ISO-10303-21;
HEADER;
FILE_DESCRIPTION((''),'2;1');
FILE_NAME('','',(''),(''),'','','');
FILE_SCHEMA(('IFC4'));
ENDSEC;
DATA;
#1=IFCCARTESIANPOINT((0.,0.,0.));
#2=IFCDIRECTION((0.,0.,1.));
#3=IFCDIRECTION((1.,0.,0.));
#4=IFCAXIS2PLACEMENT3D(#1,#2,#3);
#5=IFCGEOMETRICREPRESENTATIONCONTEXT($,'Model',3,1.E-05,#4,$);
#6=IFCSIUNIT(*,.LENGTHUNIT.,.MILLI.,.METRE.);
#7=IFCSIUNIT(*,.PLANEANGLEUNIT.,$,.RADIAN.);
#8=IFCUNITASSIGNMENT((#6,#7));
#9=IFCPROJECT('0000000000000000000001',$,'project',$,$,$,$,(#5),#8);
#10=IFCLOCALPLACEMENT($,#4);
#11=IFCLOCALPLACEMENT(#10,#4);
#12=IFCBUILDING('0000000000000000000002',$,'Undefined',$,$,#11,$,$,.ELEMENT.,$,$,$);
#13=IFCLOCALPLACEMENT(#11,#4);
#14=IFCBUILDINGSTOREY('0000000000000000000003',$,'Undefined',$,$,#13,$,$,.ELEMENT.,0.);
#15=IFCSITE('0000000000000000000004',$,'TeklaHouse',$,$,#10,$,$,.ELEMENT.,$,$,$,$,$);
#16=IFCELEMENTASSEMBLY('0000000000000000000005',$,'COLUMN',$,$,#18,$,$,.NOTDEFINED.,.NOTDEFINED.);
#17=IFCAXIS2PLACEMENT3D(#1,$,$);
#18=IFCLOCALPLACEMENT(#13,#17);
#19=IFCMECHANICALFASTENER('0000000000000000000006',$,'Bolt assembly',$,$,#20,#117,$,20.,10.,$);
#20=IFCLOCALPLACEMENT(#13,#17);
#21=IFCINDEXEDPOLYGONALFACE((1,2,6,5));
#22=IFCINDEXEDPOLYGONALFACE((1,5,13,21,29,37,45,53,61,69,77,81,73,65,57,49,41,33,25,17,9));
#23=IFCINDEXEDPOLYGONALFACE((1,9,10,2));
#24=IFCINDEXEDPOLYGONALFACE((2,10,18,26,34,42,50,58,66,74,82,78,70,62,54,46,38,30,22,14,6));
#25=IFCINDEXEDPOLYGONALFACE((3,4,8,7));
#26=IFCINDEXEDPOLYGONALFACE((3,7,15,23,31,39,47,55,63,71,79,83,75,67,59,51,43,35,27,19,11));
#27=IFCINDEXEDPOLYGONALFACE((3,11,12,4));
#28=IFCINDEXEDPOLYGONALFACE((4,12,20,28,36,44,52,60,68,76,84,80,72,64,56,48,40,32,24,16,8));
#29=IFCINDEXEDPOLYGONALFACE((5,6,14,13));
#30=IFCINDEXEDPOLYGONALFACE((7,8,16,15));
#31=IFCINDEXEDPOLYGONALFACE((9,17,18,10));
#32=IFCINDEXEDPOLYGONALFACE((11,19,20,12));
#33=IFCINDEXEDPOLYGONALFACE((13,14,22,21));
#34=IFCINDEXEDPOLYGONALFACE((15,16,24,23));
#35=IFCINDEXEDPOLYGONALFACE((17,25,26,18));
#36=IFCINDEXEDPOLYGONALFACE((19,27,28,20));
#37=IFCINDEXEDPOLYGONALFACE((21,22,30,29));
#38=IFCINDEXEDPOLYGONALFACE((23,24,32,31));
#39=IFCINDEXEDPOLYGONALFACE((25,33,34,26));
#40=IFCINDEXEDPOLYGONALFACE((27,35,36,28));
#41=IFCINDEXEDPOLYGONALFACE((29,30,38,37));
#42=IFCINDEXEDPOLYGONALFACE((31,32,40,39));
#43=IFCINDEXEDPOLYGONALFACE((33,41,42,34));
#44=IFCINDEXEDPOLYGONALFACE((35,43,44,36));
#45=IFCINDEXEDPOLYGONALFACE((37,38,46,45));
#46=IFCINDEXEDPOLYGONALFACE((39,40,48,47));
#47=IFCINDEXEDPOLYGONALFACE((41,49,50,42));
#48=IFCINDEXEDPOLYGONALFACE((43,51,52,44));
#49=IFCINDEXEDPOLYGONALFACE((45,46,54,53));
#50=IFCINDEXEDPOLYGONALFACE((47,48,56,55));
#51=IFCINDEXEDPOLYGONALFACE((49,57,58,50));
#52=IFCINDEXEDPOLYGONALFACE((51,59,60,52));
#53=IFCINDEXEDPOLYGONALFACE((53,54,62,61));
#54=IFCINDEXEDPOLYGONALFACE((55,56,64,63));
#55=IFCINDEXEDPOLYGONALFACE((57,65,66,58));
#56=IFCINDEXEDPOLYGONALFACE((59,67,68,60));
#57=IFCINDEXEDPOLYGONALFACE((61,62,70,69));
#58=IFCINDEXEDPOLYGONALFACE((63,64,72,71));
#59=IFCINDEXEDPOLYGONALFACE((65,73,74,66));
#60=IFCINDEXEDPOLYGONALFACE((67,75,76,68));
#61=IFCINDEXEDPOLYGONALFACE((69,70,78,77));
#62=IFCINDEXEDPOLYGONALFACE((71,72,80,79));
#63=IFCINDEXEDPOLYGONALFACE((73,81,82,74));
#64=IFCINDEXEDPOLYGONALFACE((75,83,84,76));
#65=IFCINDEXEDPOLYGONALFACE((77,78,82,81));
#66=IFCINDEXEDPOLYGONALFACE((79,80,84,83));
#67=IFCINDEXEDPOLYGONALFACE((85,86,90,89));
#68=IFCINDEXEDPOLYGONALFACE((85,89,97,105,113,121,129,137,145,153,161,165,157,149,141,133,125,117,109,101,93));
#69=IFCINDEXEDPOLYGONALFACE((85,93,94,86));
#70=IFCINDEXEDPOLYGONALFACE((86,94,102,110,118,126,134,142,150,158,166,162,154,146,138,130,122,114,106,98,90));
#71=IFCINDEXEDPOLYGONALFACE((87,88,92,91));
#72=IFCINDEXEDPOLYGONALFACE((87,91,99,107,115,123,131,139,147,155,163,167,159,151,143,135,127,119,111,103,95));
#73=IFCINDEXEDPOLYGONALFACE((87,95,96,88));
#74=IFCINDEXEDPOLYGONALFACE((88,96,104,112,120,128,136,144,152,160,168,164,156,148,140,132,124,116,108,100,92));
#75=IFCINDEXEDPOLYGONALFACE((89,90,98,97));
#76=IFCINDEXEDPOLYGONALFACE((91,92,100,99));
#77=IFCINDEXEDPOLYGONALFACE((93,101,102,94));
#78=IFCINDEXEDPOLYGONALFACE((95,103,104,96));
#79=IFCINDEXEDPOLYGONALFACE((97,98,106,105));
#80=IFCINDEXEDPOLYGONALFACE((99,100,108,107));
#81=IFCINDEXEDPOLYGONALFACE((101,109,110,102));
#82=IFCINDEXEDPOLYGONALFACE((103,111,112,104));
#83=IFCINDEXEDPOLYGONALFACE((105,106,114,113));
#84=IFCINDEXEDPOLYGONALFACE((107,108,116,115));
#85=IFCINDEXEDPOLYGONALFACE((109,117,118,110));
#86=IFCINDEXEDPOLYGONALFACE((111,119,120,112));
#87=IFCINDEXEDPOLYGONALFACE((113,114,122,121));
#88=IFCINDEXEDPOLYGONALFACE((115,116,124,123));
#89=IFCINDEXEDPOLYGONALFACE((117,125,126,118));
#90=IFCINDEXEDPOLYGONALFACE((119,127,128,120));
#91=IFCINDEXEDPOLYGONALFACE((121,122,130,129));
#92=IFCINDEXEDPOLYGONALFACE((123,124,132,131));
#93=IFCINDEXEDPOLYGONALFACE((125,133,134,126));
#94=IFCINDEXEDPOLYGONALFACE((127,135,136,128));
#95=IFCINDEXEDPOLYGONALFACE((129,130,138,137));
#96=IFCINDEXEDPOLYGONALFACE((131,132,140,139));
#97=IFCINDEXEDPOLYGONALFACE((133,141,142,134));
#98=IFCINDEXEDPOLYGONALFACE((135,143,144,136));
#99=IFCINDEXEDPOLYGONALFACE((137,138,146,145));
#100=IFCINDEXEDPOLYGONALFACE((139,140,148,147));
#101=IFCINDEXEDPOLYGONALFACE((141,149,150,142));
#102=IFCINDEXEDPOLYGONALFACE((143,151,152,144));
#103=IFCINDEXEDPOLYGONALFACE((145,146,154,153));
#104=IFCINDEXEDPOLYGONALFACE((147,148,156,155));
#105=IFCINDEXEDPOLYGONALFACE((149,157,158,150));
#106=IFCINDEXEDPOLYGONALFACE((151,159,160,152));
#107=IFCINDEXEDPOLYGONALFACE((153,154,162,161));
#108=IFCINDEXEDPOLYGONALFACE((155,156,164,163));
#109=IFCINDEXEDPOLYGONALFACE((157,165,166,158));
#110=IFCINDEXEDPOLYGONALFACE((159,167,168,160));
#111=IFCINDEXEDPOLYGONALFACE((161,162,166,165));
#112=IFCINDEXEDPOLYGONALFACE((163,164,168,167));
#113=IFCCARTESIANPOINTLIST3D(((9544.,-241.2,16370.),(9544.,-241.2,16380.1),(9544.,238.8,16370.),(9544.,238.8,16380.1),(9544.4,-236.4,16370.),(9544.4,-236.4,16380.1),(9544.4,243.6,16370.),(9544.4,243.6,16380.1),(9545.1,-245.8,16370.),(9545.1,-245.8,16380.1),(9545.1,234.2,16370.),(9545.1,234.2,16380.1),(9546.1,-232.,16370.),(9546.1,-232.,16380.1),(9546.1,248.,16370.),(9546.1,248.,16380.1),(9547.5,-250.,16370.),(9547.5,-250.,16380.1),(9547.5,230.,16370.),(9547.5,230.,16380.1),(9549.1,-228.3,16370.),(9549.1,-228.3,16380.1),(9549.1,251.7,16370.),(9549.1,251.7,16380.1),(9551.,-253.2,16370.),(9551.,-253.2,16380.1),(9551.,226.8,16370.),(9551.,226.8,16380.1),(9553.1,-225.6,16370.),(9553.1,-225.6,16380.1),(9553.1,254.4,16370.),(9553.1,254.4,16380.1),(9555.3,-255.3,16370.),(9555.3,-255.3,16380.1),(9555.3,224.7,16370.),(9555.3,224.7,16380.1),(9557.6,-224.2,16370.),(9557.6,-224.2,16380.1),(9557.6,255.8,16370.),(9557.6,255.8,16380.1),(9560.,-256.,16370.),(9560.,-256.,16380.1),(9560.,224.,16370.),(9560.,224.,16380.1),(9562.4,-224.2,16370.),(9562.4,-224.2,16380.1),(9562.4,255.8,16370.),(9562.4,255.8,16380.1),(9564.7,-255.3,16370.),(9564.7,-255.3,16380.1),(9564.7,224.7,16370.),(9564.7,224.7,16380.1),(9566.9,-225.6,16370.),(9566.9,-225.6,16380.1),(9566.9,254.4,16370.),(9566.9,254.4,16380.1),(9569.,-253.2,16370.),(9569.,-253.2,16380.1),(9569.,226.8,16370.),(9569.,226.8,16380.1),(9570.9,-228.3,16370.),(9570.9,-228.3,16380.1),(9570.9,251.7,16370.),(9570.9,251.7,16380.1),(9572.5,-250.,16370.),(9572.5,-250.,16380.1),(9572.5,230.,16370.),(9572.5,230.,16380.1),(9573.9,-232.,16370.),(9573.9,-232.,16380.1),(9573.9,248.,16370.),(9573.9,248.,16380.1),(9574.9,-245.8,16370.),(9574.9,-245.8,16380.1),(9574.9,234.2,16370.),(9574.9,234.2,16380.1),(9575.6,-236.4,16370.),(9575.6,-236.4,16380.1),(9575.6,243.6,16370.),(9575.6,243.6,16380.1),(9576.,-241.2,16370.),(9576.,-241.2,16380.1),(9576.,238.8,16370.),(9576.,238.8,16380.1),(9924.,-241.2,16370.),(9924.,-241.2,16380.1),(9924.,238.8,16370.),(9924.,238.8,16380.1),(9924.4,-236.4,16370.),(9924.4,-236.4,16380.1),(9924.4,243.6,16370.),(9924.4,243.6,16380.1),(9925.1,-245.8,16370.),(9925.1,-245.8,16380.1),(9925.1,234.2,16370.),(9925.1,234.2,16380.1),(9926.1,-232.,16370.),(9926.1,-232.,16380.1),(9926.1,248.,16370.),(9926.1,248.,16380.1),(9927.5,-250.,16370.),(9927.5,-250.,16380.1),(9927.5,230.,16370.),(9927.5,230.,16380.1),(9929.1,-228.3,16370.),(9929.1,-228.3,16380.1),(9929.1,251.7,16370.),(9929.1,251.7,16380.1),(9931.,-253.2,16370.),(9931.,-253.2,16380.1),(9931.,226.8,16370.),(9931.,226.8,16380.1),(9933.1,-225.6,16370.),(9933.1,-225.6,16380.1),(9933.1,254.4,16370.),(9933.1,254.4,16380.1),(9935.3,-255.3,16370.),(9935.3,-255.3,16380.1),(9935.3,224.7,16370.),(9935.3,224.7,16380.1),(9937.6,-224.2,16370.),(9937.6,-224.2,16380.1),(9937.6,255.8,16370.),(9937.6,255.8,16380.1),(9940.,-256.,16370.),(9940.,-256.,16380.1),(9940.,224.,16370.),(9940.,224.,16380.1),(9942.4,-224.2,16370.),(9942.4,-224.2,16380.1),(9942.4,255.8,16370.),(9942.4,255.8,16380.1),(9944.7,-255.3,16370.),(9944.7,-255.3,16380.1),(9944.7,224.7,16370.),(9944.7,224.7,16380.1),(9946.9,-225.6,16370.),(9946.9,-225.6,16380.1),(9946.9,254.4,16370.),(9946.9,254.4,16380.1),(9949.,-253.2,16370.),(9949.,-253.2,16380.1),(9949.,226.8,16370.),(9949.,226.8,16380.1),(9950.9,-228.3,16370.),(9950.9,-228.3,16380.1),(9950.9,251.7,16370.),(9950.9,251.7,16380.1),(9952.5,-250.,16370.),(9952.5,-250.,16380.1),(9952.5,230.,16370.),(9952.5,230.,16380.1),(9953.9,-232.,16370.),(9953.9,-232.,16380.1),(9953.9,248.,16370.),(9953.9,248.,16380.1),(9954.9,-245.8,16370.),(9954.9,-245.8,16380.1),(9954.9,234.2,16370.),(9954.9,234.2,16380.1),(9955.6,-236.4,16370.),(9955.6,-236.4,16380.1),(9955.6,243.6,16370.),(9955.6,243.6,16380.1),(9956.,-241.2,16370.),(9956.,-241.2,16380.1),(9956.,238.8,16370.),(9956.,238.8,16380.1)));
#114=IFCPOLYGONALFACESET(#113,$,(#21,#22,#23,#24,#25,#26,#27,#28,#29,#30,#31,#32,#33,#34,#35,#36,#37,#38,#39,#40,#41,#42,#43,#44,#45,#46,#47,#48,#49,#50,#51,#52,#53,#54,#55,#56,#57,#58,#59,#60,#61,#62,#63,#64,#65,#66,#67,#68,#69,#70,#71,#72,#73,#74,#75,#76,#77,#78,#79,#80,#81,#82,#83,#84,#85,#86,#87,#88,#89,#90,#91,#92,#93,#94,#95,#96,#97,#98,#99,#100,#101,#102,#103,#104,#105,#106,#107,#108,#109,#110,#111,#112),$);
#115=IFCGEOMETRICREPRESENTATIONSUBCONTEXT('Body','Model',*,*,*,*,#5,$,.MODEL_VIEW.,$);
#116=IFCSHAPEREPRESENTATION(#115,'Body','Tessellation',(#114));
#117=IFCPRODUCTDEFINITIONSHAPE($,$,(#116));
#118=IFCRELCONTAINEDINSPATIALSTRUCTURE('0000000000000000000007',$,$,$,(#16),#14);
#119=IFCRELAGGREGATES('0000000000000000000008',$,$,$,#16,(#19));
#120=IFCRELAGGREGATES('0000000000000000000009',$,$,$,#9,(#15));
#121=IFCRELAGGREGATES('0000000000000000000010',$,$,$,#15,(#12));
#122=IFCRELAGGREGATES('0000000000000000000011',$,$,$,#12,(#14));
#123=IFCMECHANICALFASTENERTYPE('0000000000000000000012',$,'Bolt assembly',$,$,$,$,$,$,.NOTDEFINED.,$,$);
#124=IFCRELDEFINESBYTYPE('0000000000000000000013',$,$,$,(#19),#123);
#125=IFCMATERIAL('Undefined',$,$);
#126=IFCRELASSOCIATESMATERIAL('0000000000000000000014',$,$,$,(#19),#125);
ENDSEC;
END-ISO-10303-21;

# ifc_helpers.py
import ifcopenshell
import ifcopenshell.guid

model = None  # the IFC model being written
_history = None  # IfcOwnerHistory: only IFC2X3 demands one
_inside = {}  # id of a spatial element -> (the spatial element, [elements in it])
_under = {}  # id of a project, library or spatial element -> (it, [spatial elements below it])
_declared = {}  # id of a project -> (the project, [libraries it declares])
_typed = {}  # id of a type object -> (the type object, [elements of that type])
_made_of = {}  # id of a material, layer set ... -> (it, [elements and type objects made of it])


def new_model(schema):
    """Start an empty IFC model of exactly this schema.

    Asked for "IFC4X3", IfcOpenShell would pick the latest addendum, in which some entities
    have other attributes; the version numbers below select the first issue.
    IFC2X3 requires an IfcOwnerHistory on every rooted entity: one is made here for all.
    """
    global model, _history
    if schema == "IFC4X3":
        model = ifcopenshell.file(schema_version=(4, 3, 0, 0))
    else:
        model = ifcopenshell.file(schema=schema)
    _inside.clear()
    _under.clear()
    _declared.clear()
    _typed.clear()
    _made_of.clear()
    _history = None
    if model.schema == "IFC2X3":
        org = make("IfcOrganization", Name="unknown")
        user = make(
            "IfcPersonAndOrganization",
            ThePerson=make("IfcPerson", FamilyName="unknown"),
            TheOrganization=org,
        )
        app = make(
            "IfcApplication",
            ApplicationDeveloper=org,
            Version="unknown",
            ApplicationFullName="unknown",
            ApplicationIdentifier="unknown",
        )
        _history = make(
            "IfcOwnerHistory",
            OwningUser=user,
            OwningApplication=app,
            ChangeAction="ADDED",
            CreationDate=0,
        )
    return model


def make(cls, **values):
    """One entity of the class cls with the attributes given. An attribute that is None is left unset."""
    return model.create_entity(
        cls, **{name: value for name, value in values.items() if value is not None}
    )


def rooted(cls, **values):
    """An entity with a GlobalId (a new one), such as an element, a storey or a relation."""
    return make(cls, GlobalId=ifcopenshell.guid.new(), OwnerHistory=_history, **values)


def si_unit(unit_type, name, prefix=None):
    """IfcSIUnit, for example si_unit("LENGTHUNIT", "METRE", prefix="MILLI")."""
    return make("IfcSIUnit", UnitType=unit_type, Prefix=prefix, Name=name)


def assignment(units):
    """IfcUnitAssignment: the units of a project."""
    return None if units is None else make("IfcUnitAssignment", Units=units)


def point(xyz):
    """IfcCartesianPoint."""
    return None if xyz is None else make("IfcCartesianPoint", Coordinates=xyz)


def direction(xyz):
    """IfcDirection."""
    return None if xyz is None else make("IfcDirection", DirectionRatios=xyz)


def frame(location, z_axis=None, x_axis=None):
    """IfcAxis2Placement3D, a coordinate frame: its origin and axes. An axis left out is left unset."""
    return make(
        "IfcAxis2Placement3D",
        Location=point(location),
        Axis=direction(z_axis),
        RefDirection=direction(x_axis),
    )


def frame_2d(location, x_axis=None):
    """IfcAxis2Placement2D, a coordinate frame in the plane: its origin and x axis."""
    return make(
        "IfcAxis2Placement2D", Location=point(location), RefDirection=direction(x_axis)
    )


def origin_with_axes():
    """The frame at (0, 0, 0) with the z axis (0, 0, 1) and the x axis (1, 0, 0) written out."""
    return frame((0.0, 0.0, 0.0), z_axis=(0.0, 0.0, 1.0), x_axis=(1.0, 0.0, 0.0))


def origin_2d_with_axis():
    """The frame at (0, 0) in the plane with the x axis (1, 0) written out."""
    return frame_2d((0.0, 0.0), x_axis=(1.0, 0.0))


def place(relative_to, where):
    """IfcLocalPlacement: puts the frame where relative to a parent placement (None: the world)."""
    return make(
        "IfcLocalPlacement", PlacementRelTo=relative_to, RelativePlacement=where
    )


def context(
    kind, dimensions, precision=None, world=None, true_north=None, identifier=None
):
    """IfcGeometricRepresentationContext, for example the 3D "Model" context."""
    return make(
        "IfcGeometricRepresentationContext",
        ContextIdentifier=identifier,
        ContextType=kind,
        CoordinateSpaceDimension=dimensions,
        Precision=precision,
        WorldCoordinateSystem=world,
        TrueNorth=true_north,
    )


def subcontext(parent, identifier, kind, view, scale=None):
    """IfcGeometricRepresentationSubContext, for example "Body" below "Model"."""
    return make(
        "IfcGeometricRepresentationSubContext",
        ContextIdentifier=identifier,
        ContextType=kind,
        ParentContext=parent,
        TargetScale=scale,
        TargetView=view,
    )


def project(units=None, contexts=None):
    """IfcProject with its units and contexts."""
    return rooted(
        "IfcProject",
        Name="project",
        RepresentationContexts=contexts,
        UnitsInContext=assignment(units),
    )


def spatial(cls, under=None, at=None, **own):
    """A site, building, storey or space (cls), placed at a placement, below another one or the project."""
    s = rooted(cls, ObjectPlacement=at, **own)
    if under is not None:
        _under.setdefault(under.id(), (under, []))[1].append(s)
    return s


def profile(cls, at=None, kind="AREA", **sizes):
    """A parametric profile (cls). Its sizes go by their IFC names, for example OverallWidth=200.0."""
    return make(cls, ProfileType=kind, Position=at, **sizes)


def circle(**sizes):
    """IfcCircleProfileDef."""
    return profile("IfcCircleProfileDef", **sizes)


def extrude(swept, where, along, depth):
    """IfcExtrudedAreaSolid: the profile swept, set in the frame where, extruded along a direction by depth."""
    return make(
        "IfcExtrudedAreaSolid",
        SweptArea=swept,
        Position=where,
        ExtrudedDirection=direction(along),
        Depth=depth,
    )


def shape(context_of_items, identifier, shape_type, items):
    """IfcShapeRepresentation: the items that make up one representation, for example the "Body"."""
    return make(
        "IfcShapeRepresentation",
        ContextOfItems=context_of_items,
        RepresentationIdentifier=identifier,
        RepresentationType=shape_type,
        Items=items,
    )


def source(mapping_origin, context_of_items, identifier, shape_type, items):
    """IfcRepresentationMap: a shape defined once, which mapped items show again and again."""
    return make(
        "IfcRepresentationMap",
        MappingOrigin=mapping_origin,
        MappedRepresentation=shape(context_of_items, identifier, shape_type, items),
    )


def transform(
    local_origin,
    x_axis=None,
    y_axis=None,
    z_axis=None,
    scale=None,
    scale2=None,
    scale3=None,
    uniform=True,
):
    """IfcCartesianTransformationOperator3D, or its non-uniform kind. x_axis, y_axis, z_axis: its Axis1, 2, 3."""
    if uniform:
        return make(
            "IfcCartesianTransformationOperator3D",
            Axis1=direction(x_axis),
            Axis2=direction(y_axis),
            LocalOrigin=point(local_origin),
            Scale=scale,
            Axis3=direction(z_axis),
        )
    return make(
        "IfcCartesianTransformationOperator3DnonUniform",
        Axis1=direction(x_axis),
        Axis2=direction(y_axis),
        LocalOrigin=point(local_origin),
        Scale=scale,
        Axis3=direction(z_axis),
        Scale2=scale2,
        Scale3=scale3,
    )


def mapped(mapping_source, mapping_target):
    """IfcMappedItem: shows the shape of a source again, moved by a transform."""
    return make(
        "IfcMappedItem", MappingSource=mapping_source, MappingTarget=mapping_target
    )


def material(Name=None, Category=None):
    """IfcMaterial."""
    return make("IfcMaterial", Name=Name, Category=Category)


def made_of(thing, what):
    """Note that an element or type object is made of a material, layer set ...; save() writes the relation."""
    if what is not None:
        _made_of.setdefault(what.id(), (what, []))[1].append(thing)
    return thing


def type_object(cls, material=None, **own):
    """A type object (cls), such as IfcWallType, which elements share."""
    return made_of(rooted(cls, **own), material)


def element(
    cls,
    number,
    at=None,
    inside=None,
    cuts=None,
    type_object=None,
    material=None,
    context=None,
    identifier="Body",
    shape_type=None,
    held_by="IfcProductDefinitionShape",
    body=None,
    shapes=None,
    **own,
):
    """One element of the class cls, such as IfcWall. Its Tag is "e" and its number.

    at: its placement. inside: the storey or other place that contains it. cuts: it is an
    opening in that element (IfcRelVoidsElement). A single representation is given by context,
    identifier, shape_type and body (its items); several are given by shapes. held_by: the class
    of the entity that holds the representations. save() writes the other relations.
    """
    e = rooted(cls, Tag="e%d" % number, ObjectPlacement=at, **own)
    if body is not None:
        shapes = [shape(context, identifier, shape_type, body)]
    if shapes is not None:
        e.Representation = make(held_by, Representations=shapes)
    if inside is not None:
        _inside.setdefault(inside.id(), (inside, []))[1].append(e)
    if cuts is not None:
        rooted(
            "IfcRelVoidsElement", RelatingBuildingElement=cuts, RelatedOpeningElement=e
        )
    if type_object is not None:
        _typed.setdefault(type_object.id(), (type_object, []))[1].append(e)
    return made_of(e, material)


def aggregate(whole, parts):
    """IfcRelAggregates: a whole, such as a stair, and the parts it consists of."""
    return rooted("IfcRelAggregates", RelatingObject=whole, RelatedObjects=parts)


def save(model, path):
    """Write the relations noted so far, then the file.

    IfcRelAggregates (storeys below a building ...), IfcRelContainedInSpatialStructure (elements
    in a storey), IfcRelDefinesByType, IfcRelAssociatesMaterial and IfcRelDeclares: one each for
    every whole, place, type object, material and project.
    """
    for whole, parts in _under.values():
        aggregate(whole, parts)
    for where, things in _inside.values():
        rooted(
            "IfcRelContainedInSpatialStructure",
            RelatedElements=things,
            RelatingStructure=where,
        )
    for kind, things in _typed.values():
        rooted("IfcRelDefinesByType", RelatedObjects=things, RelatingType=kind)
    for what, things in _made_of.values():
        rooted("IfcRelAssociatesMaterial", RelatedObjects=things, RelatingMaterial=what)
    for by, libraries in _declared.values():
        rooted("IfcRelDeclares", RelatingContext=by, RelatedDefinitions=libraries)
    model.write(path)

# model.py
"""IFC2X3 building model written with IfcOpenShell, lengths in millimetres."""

from ifc_helpers import new_model, si_unit, frame, origin_with_axes, origin_2d_with_axis, place, context, subcontext, project, spatial, circle, extrude, source, transform, mapped, material, type_object, element, aggregate, save


model = new_model("IFC2X3")

# Units and contexts
model_context = context("Model", 3, precision=1e-05, world=origin_with_axes())
body_context = subcontext(model_context, "Body", "Model", "MODEL_VIEW")
ifc_project = project(units=[si_unit("LENGTHUNIT", "METRE", prefix="MILLI"), si_unit("PLANEANGLEUNIT", "RADIAN")], contexts=[model_context])

# Site, building, storey
site_placement = place(None, origin_with_axes())
site = spatial("IfcSite", under=ifc_project, at=site_placement, Name="TeklaHouse", CompositionType="ELEMENT")
building_placement = place(site_placement, origin_with_axes())
building = spatial("IfcBuilding", under=site, at=building_placement, Name="Undefined", CompositionType="ELEMENT")
storey_placement = place(building_placement, origin_with_axes())
storey = spatial("IfcBuildingStorey", under=building, at=storey_placement, Name="Undefined", CompositionType="ELEMENT", Elevation=0.0)

# Element assembly
assembly_1_placement = place(storey_placement, origin_with_axes())
assembly_1 = element("IfcElementAssembly", 1, at=assembly_1_placement, inside=storey, Name="COLUMN", AssemblyPlace="NOTDEFINED", PredefinedType="NOTDEFINED")

# Mechanical fastener
ifc_material_1 = material(Name="Undefined")
mechanical_fastener_type = type_object("IfcMechanicalFastenerType", Name="Bolt assembly")
shared_shape_1 = source(origin_with_axes(), body_context, "Body", "SweptSolid", [
    extrude(circle(Radius=16.0, at=origin_2d_with_axis()), frame((0.0, -10.0, 0.0), z_axis=(0.0, 1.0, 0.0), x_axis=(1.0, 0.0, 0.0)), (0.0, 0.0, 1.0), 10.1),
])
mechanical_fastener_1_placement = place(assembly_1_placement, frame((9750.0, 200.0, 16380.0), z_axis=(-1.0, 0.0, 0.0), x_axis=(0.0, -1.0, 0.0)))
mechanical_fastener_1 = element("IfcMechanicalFastener", 2, at=mechanical_fastener_1_placement, type_object=mechanical_fastener_type, material=ifc_material_1, Name="Bolt assembly", NominalDiameter=20.0, NominalLength=10.0, context=body_context, shape_type="MappedRepresentation", body=[
    mapped(shared_shape_1, transform((-40.0, 0.0, -190.0))),
    mapped(shared_shape_1, transform((-40.0, 0.0, 190.0))),
    mapped(shared_shape_1, transform((440.0, 0.0, -190.0))),
    mapped(shared_shape_1, transform((440.0, 0.0, 190.0))),
])
aggregate(assembly_1, [mechanical_fastener_1])

save(model, "model.ifc")
